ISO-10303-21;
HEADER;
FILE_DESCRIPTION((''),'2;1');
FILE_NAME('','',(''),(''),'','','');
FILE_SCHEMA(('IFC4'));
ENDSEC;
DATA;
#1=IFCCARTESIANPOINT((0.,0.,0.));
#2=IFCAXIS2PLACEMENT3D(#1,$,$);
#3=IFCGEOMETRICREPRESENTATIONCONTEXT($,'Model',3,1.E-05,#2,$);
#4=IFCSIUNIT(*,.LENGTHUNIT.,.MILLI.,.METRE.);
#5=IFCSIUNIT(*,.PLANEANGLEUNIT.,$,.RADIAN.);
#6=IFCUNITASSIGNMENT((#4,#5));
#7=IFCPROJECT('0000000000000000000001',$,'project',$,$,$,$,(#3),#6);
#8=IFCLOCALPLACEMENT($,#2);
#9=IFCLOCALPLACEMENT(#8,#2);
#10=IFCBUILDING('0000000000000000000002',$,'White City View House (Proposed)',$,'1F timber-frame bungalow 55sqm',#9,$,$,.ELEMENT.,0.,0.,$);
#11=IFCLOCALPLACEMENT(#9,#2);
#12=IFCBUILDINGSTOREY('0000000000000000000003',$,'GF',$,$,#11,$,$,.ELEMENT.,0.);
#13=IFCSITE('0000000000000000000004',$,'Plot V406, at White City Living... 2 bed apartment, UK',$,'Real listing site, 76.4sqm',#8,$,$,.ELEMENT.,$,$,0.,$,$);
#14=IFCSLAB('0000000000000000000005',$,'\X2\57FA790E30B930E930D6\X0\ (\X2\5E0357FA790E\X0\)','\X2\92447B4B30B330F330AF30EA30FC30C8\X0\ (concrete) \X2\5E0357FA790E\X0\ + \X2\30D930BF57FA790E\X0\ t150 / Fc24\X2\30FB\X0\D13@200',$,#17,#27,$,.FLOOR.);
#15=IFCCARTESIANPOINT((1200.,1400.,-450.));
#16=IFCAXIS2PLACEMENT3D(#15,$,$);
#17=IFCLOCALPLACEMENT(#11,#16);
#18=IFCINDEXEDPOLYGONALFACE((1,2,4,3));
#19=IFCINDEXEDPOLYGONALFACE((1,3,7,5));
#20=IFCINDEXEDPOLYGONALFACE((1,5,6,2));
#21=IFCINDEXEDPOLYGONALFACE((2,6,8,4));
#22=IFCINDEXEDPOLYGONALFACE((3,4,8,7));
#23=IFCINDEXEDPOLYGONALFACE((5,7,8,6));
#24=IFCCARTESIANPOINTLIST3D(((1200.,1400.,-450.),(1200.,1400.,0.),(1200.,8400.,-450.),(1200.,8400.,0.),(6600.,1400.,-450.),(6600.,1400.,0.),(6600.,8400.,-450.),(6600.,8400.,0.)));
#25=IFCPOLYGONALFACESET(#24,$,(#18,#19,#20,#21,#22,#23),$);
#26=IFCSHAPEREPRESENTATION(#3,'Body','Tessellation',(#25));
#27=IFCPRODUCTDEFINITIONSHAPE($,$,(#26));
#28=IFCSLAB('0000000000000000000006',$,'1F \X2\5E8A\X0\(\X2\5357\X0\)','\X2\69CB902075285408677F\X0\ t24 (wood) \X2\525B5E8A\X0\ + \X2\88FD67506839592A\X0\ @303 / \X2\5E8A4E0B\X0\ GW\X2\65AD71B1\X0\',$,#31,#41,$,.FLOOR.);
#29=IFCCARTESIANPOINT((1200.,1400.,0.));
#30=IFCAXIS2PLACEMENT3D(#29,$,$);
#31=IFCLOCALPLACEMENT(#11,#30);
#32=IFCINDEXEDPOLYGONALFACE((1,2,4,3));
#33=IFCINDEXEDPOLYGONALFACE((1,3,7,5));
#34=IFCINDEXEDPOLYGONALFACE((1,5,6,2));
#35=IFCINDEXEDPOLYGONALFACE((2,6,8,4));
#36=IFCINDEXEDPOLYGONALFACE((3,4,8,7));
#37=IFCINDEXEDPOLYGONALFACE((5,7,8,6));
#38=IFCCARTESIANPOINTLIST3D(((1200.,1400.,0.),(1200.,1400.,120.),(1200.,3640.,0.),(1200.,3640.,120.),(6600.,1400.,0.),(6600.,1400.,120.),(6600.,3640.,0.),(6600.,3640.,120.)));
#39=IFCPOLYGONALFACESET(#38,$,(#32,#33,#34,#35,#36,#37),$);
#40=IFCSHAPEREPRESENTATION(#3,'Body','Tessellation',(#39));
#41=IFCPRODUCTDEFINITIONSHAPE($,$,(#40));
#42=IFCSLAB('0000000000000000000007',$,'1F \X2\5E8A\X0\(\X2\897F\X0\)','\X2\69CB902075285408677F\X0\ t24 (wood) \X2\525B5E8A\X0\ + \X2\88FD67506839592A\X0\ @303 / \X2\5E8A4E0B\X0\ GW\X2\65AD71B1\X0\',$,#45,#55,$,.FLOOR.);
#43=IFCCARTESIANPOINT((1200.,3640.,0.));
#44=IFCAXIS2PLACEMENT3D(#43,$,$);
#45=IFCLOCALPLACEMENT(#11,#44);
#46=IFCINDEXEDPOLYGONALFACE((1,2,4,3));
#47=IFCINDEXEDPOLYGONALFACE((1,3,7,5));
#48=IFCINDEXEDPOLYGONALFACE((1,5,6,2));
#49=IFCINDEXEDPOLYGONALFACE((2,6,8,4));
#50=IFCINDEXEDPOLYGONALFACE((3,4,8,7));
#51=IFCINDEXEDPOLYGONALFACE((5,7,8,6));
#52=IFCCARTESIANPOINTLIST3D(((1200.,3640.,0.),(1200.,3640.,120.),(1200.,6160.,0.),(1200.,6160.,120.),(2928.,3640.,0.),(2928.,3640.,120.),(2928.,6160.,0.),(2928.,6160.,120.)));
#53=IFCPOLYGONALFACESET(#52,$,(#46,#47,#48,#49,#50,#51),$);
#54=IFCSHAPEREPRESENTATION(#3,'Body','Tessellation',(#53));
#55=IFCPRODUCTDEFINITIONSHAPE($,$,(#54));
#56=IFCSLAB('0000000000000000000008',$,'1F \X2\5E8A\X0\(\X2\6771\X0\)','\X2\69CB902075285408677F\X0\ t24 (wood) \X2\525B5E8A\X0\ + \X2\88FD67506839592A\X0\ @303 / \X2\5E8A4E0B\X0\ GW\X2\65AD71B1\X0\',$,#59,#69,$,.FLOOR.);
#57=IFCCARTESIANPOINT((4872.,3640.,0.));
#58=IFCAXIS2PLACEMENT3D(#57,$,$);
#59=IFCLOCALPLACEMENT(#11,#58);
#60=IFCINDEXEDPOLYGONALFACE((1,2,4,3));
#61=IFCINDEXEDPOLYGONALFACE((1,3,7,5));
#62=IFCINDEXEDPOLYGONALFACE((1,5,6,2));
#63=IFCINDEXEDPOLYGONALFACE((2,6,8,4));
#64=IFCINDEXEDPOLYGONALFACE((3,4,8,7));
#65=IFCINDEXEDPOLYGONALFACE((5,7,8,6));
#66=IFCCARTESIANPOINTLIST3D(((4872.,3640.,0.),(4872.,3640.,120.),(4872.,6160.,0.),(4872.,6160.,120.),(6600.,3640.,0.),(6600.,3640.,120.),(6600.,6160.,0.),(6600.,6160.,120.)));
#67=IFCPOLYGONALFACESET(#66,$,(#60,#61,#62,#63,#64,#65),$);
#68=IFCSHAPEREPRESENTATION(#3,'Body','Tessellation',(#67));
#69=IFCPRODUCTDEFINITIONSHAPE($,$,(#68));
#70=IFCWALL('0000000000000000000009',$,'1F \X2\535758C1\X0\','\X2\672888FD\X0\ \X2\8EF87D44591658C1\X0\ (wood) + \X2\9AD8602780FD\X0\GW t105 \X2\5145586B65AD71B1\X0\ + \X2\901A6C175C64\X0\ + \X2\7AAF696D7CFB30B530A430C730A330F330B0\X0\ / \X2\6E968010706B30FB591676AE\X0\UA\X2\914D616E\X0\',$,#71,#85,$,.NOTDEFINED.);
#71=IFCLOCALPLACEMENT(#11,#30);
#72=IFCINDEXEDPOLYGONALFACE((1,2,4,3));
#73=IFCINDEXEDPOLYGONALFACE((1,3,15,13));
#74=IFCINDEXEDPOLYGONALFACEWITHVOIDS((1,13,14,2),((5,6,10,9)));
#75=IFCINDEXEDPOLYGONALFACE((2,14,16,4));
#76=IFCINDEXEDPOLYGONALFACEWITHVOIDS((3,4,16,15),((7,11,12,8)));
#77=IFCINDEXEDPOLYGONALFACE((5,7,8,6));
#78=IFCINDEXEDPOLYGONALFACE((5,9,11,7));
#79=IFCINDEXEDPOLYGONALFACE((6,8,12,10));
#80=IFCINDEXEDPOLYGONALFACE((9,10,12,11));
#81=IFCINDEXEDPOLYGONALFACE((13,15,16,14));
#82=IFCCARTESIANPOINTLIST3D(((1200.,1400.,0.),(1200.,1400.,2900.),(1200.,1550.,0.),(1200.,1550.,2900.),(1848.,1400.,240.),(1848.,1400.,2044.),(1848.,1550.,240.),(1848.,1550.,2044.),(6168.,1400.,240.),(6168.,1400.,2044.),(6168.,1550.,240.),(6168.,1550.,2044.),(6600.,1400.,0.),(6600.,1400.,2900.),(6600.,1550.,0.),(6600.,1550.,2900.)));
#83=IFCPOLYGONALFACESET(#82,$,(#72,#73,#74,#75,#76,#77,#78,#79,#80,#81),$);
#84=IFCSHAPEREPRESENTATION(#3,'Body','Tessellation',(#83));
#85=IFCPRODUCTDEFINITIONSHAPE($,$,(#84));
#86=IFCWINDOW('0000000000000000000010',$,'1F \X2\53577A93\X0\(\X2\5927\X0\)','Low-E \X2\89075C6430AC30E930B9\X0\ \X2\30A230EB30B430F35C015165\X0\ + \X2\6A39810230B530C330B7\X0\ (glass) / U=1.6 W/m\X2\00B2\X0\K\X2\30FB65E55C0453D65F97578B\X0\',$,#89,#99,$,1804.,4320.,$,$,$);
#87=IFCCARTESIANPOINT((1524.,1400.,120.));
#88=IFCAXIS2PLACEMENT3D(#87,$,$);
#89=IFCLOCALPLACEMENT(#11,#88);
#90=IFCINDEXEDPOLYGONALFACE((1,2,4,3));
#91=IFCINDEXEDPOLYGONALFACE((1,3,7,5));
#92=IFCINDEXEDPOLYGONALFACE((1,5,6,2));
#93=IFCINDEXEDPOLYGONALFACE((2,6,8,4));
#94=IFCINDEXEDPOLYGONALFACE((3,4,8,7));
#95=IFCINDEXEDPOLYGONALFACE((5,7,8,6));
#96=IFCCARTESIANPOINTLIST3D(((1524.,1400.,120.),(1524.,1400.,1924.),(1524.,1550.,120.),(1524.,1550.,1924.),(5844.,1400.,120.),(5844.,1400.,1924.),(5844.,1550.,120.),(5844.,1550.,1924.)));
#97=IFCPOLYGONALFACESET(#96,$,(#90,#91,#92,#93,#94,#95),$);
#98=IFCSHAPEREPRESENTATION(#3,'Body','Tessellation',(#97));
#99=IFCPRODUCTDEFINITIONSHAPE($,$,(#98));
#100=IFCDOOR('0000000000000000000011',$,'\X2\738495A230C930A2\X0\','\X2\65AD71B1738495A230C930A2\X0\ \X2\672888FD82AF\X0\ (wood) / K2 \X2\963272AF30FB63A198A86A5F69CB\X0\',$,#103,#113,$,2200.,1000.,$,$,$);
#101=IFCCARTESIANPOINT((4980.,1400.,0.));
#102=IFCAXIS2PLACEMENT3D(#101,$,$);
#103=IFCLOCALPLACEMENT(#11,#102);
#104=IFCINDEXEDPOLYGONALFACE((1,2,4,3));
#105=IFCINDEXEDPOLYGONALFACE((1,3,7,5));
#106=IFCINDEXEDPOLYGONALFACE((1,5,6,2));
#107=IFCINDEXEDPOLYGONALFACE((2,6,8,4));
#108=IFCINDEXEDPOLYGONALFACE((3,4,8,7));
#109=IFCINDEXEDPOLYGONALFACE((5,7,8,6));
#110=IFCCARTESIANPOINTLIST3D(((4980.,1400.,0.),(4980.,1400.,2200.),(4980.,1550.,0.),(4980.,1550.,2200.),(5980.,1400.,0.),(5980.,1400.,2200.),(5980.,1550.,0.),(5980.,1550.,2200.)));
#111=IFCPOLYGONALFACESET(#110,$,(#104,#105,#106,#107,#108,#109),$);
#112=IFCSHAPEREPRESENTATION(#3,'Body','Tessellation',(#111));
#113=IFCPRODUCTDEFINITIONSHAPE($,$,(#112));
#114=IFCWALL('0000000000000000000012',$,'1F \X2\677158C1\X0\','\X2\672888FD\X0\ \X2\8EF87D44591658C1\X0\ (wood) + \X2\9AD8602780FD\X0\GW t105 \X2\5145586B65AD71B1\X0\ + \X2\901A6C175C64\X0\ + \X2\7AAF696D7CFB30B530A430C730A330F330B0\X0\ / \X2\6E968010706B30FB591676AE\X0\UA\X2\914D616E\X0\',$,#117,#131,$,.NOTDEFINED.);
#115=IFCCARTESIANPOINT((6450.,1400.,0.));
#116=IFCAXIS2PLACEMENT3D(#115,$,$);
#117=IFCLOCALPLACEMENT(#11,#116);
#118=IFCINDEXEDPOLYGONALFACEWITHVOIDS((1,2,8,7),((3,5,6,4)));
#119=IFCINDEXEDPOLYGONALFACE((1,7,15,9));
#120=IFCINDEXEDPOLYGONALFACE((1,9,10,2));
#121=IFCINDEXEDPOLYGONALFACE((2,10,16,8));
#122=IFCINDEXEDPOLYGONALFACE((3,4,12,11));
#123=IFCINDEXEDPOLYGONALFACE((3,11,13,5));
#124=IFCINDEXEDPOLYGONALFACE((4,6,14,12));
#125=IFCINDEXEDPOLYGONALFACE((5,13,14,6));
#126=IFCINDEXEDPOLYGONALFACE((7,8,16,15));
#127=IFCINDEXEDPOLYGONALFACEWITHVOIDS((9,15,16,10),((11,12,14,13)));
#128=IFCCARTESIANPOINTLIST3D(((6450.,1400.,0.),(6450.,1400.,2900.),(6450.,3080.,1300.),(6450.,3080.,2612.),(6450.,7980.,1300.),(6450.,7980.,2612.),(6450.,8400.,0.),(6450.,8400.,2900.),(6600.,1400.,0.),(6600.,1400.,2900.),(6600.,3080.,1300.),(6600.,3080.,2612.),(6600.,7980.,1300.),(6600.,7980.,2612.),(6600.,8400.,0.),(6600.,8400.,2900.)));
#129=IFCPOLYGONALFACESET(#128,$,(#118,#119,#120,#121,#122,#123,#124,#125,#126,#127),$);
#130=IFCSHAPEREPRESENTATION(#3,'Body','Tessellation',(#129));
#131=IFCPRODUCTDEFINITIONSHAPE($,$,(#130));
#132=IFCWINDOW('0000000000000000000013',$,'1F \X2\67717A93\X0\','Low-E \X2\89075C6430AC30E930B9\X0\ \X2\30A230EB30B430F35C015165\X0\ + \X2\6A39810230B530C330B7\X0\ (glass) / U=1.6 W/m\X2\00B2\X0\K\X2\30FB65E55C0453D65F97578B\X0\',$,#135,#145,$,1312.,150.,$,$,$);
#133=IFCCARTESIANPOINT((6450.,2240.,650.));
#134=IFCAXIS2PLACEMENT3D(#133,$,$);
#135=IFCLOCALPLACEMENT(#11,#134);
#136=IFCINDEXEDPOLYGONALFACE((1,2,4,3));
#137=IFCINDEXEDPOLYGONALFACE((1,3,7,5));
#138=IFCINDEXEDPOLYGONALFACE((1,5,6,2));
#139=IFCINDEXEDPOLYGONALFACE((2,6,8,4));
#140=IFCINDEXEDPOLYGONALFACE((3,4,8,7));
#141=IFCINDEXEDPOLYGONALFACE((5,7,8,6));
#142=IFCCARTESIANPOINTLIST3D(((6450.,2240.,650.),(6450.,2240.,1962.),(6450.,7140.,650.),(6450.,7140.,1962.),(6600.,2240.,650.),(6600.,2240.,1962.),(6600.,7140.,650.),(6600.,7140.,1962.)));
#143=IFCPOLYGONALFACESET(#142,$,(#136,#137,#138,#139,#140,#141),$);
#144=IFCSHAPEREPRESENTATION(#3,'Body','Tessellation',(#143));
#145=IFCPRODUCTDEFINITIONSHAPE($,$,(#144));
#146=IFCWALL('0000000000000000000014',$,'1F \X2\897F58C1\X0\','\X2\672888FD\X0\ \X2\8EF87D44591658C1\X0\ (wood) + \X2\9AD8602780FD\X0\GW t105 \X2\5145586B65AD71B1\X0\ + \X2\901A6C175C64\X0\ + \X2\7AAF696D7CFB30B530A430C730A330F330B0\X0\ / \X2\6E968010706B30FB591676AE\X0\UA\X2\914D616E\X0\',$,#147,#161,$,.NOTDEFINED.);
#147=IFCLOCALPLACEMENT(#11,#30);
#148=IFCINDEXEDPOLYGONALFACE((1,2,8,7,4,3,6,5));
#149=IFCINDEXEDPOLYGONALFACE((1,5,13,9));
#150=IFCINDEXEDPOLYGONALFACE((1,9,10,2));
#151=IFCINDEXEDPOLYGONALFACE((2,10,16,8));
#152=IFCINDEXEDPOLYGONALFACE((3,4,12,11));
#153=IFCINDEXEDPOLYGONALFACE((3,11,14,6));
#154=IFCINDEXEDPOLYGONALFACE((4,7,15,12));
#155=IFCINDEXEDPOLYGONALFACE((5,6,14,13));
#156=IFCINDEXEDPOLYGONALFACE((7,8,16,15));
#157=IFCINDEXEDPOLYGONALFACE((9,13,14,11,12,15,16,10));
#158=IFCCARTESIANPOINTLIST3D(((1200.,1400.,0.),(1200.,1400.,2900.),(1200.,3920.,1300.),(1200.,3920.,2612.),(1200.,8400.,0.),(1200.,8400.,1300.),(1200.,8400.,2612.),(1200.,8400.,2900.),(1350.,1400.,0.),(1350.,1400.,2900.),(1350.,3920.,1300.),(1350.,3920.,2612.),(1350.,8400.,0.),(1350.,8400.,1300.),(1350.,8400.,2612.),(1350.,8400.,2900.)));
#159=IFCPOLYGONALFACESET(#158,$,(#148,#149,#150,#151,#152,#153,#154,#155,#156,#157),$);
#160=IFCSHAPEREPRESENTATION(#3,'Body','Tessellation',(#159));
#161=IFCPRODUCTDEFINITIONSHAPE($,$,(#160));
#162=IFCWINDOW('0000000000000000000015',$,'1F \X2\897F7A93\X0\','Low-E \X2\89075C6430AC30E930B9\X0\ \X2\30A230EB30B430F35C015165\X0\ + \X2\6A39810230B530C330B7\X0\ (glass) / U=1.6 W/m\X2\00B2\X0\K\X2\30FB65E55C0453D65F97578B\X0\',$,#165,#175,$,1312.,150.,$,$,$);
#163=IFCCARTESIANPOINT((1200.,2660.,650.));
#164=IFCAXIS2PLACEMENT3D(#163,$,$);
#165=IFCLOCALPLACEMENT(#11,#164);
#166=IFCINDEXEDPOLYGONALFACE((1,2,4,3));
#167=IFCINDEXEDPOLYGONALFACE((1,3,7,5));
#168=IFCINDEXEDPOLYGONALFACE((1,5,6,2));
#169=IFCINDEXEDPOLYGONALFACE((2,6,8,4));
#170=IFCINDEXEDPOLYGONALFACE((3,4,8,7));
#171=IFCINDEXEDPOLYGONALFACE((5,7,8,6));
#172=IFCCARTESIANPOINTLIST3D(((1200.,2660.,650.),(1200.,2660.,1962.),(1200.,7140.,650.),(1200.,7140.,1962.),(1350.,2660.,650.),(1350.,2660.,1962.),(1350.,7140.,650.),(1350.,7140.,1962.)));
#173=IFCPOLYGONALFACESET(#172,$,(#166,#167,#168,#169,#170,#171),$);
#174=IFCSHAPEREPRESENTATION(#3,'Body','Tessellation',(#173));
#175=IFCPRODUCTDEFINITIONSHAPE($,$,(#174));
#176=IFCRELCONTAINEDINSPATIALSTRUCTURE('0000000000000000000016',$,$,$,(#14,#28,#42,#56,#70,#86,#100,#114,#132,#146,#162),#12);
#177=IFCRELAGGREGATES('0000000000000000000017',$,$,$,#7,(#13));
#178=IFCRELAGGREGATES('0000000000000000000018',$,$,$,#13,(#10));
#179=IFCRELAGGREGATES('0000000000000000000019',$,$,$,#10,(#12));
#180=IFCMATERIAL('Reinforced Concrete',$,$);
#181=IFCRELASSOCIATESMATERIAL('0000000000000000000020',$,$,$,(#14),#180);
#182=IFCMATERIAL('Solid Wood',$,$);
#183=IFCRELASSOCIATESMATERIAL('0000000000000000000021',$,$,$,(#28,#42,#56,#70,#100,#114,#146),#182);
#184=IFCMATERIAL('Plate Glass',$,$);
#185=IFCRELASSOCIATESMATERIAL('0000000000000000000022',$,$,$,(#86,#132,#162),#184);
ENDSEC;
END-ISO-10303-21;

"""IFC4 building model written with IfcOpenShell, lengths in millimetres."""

from ifc_helpers import new_model, si_unit, frame, frame_2d, origin, place, context, project, spatial, rectangle, extrude, material, element, fill, save


model = new_model("IFC4")

# Units and contexts
model_context = context("Model", 3, precision=1e-05, world=origin())
ifc_project = project(units=[si_unit("LENGTHUNIT", "METRE", prefix="MILLI"), si_unit("PLANEANGLEUNIT", "RADIAN")], contexts=[model_context])

# Site, building, storey
site_placement = place(None, origin())
site = spatial("IfcSite", under=ifc_project, at=site_placement, Name="Plot V406, at White City Living... 2 bed apartment, UK", ObjectType="Real listing site, 76.4sqm", CompositionType="ELEMENT", RefElevation=0.0)
building_placement = place(site_placement, origin())
building = spatial("IfcBuilding", under=site, at=building_placement, Name="White City View House (Proposed)", ObjectType="1F timber-frame bungalow 55sqm", CompositionType="ELEMENT", ElevationOfRefHeight=0.0, ElevationOfTerrain=0.0)
storey_placement = place(building_placement, origin())
storey = spatial("IfcBuildingStorey", under=building, at=storey_placement, Name="GF", CompositionType="ELEMENT", Elevation=0.0)

# Slabs
ifc_material_1 = material(Name="Reinforced Concrete")
slab_1_placement = place(storey_placement, frame((1200.0, 1400.0, -450.0)))
element("IfcSlab", 1, at=slab_1_placement, inside=storey, material=ifc_material_1, Name="基礎スラブ (布基礎)", Description="鉄筋コンクリート (concrete) 布基礎 + ベタ基礎 t150 / Fc24・D13@200", PredefinedType="FLOOR", context=model_context, shape_type="SweptSolid", body=[
    extrude(rectangle(XDim=5400.0, YDim=7000.0, at=frame_2d((2700.0, 3500.0))), frame((1200.0, 1400.0, -450.0)), (0.0, 0.0, 1.0), 450.0),
])
ifc_material_2 = material(Name="Solid Wood")
slab_2_placement = place(storey_placement, frame((1200.0, 1400.0, 0.0)))
element("IfcSlab", 2, at=slab_2_placement, inside=storey, material=ifc_material_2, Name="1F 床(南)", Description="構造用合板 t24 (wood) 剛床 + 製材根太 @303 / 床下 GW断熱", PredefinedType="FLOOR", context=model_context, shape_type="SweptSolid", body=[
    extrude(rectangle(XDim=5400.0, YDim=2240.0, at=frame_2d((2700.0, 1120.0))), frame((1200.0, 1400.0, 0.0)), (0.0, 0.0, 1.0), 120.0),
])
slab_3_placement = place(storey_placement, frame((1200.0, 3640.0, 0.0)))
element("IfcSlab", 3, at=slab_3_placement, inside=storey, material=ifc_material_2, Name="1F 床(西)", Description="構造用合板 t24 (wood) 剛床 + 製材根太 @303 / 床下 GW断熱", PredefinedType="FLOOR", context=model_context, shape_type="SweptSolid", body=[
    extrude(rectangle(XDim=1728.0, YDim=2520.0, at=frame_2d((864.0, 1260.0))), frame((1200.0, 3640.0, 0.0)), (0.0, 0.0, 1.0), 120.0),
])
slab_4_placement = place(storey_placement, frame((4872.0, 3640.0, 0.0)))
element("IfcSlab", 4, at=slab_4_placement, inside=storey, material=ifc_material_2, Name="1F 床(東)", Description="構造用合板 t24 (wood) 剛床 + 製材根太 @303 / 床下 GW断熱", PredefinedType="FLOOR", context=model_context, shape_type="SweptSolid", body=[
    extrude(rectangle(XDim=1728.0, YDim=2520.0, at=frame_2d((864.0, 1260.0))), frame((4872.0, 3640.0, 0.0)), (0.0, 0.0, 1.0), 120.0),
])

# Wall, openings, window, door
wall_1_placement = place(storey_placement, frame((1200.0, 1400.0, 0.0)))
wall_1 = element("IfcWall", 5, at=wall_1_placement, inside=storey, material=ifc_material_2, Name="1F 南壁", Description="木製 軸組外壁 (wood) + 高性能GW t105 充填断熱 + 通気層 + 窯業系サイディング / 準耐火・外皮UA配慮", PredefinedType="NOTDEFINED", context=model_context, shape_type="SweptSolid", body=[
    extrude(rectangle(XDim=5400.0, YDim=150.0, at=frame_2d((2700.0, 75.0))), frame((1200.0, 1400.0, 0.0)), (0.0, 0.0, 1.0), 2900.0),
])
opening_1_placement = place(storey_placement, frame((1524.0, 1400.0, 120.0)))
opening_1 = element("IfcOpeningElement", 6, at=opening_1_placement, cuts=wall_1, PredefinedType="NOTDEFINED", context=model_context, shape_type="SweptSolid", body=[
    extrude(rectangle(XDim=4320.0, YDim=150.0, at=frame_2d((2160.0, 75.0))), frame((1524.0, 1400.0, 120.0)), (0.0, 0.0, 1.0), 1804.0),
])
opening_2_placement = place(storey_placement, frame((4980.0, 1400.0, 0.0)))
opening_2 = element("IfcOpeningElement", 7, at=opening_2_placement, cuts=wall_1, PredefinedType="NOTDEFINED", context=model_context, shape_type="SweptSolid", body=[
    extrude(rectangle(XDim=1000.0, YDim=150.0, at=frame_2d((500.0, 75.0))), frame((4980.0, 1400.0, 0.0)), (0.0, 0.0, 1.0), 2200.0),
])
ifc_material_3 = material(Name="Plate Glass")
window_1_placement = place(storey_placement, frame((1524.0, 1400.0, 120.0)))
window_1 = element("IfcWindow", 8, at=window_1_placement, inside=storey, material=ifc_material_3, Name="1F 南窓(大)", Description="Low-E 複層ガラス アルゴン封入 + 樹脂サッシ (glass) / U=1.6 W/m²K・日射取得型", OverallHeight=1804.0, OverallWidth=4320.0, context=model_context, shape_type="SweptSolid", body=[
    extrude(rectangle(XDim=4320.0, YDim=150.0, at=frame_2d((2160.0, 75.0))), frame((1524.0, 1400.0, 120.0)), (0.0, 0.0, 1.0), 1804.0),
])
fill(opening_1, window_1)
door_placement = place(storey_placement, frame((4980.0, 1400.0, 0.0)))
door = element("IfcDoor", 9, at=door_placement, inside=storey, material=ifc_material_2, Name="玄関ドア", Description="断熱玄関ドア 木製芯 (wood) / K2 防犯・採風機構", OverallHeight=2200.0, OverallWidth=1000.0, context=model_context, shape_type="SweptSolid", body=[
    extrude(rectangle(XDim=1000.0, YDim=150.0, at=frame_2d((500.0, 75.0))), frame((4980.0, 1400.0, 0.0)), (0.0, 0.0, 1.0), 2200.0),
])
fill(opening_2, door)

# Walls, openings, windows
wall_2_placement = place(storey_placement, frame((6450.0, 1400.0, 0.0)))
wall_2 = element("IfcWall", 10, at=wall_2_placement, inside=storey, material=ifc_material_2, Name="1F 東壁", Description="木製 軸組外壁 (wood) + 高性能GW t105 充填断熱 + 通気層 + 窯業系サイディング / 準耐火・外皮UA配慮", PredefinedType="NOTDEFINED", context=model_context, shape_type="SweptSolid", body=[
    extrude(rectangle(XDim=150.0, YDim=7000.0, at=frame_2d((75.0, 3500.0))), frame((6450.0, 1400.0, 0.0)), (0.0, 0.0, 1.0), 2900.0),
])
opening_3_placement = place(storey_placement, frame((6450.0, 2240.0, 650.0)))
opening_3 = element("IfcOpeningElement", 11, at=opening_3_placement, cuts=wall_2, PredefinedType="NOTDEFINED", context=model_context, shape_type="SweptSolid", body=[
    extrude(rectangle(XDim=150.0, YDim=4900.0, at=frame_2d((75.0, 2450.0))), frame((6450.0, 2240.0, 650.0)), (0.0, 0.0, 1.0), 1312.0),
])
window_2_placement = place(storey_placement, frame((6450.0, 2240.0, 650.0)))
window_2 = element("IfcWindow", 12, at=window_2_placement, inside=storey, material=ifc_material_3, Name="1F 東窓", Description="Low-E 複層ガラス アルゴン封入 + 樹脂サッシ (glass) / U=1.6 W/m²K・日射取得型", OverallHeight=1312.0, OverallWidth=150.0, context=model_context, shape_type="SweptSolid", body=[
    extrude(rectangle(XDim=150.0, YDim=4900.0, at=frame_2d((75.0, 2450.0))), frame((6450.0, 2240.0, 650.0)), (0.0, 0.0, 1.0), 1312.0),
])
fill(opening_3, window_2)
wall_3_placement = place(storey_placement, frame((1200.0, 1400.0, 0.0)))
wall_3 = element("IfcWall", 13, at=wall_3_placement, inside=storey, material=ifc_material_2, Name="1F 西壁", Description="木製 軸組外壁 (wood) + 高性能GW t105 充填断熱 + 通気層 + 窯業系サイディング / 準耐火・外皮UA配慮", PredefinedType="NOTDEFINED", context=model_context, shape_type="SweptSolid", body=[
    extrude(rectangle(XDim=150.0, YDim=7000.0, at=frame_2d((75.0, 3500.0))), frame((1200.0, 1400.0, 0.0)), (0.0, 0.0, 1.0), 2900.0),
])
opening_4_placement = place(storey_placement, frame((1200.0, 2660.0, 650.0)))
opening_4 = element("IfcOpeningElement", 14, at=opening_4_placement, cuts=wall_3, PredefinedType="NOTDEFINED", context=model_context, shape_type="SweptSolid", body=[
    extrude(rectangle(XDim=150.0, YDim=4480.0, at=frame_2d((75.0, 2240.0))), frame((1200.0, 2660.0, 650.0)), (0.0, 0.0, 1.0), 1312.0),
])
window_3_placement = place(storey_placement, frame((1200.0, 2660.0, 650.0)))
window_3 = element("IfcWindow", 15, at=window_3_placement, inside=storey, material=ifc_material_3, Name="1F 西窓", Description="Low-E 複層ガラス アルゴン封入 + 樹脂サッシ (glass) / U=1.6 W/m²K・日射取得型", OverallHeight=1312.0, OverallWidth=150.0, context=model_context, shape_type="SweptSolid", body=[
    extrude(rectangle(XDim=150.0, YDim=4480.0, at=frame_2d((75.0, 2240.0))), frame((1200.0, 2660.0, 650.0)), (0.0, 0.0, 1.0), 1312.0),
])
fill(opening_4, window_3)

save(model, "model.ifc")
